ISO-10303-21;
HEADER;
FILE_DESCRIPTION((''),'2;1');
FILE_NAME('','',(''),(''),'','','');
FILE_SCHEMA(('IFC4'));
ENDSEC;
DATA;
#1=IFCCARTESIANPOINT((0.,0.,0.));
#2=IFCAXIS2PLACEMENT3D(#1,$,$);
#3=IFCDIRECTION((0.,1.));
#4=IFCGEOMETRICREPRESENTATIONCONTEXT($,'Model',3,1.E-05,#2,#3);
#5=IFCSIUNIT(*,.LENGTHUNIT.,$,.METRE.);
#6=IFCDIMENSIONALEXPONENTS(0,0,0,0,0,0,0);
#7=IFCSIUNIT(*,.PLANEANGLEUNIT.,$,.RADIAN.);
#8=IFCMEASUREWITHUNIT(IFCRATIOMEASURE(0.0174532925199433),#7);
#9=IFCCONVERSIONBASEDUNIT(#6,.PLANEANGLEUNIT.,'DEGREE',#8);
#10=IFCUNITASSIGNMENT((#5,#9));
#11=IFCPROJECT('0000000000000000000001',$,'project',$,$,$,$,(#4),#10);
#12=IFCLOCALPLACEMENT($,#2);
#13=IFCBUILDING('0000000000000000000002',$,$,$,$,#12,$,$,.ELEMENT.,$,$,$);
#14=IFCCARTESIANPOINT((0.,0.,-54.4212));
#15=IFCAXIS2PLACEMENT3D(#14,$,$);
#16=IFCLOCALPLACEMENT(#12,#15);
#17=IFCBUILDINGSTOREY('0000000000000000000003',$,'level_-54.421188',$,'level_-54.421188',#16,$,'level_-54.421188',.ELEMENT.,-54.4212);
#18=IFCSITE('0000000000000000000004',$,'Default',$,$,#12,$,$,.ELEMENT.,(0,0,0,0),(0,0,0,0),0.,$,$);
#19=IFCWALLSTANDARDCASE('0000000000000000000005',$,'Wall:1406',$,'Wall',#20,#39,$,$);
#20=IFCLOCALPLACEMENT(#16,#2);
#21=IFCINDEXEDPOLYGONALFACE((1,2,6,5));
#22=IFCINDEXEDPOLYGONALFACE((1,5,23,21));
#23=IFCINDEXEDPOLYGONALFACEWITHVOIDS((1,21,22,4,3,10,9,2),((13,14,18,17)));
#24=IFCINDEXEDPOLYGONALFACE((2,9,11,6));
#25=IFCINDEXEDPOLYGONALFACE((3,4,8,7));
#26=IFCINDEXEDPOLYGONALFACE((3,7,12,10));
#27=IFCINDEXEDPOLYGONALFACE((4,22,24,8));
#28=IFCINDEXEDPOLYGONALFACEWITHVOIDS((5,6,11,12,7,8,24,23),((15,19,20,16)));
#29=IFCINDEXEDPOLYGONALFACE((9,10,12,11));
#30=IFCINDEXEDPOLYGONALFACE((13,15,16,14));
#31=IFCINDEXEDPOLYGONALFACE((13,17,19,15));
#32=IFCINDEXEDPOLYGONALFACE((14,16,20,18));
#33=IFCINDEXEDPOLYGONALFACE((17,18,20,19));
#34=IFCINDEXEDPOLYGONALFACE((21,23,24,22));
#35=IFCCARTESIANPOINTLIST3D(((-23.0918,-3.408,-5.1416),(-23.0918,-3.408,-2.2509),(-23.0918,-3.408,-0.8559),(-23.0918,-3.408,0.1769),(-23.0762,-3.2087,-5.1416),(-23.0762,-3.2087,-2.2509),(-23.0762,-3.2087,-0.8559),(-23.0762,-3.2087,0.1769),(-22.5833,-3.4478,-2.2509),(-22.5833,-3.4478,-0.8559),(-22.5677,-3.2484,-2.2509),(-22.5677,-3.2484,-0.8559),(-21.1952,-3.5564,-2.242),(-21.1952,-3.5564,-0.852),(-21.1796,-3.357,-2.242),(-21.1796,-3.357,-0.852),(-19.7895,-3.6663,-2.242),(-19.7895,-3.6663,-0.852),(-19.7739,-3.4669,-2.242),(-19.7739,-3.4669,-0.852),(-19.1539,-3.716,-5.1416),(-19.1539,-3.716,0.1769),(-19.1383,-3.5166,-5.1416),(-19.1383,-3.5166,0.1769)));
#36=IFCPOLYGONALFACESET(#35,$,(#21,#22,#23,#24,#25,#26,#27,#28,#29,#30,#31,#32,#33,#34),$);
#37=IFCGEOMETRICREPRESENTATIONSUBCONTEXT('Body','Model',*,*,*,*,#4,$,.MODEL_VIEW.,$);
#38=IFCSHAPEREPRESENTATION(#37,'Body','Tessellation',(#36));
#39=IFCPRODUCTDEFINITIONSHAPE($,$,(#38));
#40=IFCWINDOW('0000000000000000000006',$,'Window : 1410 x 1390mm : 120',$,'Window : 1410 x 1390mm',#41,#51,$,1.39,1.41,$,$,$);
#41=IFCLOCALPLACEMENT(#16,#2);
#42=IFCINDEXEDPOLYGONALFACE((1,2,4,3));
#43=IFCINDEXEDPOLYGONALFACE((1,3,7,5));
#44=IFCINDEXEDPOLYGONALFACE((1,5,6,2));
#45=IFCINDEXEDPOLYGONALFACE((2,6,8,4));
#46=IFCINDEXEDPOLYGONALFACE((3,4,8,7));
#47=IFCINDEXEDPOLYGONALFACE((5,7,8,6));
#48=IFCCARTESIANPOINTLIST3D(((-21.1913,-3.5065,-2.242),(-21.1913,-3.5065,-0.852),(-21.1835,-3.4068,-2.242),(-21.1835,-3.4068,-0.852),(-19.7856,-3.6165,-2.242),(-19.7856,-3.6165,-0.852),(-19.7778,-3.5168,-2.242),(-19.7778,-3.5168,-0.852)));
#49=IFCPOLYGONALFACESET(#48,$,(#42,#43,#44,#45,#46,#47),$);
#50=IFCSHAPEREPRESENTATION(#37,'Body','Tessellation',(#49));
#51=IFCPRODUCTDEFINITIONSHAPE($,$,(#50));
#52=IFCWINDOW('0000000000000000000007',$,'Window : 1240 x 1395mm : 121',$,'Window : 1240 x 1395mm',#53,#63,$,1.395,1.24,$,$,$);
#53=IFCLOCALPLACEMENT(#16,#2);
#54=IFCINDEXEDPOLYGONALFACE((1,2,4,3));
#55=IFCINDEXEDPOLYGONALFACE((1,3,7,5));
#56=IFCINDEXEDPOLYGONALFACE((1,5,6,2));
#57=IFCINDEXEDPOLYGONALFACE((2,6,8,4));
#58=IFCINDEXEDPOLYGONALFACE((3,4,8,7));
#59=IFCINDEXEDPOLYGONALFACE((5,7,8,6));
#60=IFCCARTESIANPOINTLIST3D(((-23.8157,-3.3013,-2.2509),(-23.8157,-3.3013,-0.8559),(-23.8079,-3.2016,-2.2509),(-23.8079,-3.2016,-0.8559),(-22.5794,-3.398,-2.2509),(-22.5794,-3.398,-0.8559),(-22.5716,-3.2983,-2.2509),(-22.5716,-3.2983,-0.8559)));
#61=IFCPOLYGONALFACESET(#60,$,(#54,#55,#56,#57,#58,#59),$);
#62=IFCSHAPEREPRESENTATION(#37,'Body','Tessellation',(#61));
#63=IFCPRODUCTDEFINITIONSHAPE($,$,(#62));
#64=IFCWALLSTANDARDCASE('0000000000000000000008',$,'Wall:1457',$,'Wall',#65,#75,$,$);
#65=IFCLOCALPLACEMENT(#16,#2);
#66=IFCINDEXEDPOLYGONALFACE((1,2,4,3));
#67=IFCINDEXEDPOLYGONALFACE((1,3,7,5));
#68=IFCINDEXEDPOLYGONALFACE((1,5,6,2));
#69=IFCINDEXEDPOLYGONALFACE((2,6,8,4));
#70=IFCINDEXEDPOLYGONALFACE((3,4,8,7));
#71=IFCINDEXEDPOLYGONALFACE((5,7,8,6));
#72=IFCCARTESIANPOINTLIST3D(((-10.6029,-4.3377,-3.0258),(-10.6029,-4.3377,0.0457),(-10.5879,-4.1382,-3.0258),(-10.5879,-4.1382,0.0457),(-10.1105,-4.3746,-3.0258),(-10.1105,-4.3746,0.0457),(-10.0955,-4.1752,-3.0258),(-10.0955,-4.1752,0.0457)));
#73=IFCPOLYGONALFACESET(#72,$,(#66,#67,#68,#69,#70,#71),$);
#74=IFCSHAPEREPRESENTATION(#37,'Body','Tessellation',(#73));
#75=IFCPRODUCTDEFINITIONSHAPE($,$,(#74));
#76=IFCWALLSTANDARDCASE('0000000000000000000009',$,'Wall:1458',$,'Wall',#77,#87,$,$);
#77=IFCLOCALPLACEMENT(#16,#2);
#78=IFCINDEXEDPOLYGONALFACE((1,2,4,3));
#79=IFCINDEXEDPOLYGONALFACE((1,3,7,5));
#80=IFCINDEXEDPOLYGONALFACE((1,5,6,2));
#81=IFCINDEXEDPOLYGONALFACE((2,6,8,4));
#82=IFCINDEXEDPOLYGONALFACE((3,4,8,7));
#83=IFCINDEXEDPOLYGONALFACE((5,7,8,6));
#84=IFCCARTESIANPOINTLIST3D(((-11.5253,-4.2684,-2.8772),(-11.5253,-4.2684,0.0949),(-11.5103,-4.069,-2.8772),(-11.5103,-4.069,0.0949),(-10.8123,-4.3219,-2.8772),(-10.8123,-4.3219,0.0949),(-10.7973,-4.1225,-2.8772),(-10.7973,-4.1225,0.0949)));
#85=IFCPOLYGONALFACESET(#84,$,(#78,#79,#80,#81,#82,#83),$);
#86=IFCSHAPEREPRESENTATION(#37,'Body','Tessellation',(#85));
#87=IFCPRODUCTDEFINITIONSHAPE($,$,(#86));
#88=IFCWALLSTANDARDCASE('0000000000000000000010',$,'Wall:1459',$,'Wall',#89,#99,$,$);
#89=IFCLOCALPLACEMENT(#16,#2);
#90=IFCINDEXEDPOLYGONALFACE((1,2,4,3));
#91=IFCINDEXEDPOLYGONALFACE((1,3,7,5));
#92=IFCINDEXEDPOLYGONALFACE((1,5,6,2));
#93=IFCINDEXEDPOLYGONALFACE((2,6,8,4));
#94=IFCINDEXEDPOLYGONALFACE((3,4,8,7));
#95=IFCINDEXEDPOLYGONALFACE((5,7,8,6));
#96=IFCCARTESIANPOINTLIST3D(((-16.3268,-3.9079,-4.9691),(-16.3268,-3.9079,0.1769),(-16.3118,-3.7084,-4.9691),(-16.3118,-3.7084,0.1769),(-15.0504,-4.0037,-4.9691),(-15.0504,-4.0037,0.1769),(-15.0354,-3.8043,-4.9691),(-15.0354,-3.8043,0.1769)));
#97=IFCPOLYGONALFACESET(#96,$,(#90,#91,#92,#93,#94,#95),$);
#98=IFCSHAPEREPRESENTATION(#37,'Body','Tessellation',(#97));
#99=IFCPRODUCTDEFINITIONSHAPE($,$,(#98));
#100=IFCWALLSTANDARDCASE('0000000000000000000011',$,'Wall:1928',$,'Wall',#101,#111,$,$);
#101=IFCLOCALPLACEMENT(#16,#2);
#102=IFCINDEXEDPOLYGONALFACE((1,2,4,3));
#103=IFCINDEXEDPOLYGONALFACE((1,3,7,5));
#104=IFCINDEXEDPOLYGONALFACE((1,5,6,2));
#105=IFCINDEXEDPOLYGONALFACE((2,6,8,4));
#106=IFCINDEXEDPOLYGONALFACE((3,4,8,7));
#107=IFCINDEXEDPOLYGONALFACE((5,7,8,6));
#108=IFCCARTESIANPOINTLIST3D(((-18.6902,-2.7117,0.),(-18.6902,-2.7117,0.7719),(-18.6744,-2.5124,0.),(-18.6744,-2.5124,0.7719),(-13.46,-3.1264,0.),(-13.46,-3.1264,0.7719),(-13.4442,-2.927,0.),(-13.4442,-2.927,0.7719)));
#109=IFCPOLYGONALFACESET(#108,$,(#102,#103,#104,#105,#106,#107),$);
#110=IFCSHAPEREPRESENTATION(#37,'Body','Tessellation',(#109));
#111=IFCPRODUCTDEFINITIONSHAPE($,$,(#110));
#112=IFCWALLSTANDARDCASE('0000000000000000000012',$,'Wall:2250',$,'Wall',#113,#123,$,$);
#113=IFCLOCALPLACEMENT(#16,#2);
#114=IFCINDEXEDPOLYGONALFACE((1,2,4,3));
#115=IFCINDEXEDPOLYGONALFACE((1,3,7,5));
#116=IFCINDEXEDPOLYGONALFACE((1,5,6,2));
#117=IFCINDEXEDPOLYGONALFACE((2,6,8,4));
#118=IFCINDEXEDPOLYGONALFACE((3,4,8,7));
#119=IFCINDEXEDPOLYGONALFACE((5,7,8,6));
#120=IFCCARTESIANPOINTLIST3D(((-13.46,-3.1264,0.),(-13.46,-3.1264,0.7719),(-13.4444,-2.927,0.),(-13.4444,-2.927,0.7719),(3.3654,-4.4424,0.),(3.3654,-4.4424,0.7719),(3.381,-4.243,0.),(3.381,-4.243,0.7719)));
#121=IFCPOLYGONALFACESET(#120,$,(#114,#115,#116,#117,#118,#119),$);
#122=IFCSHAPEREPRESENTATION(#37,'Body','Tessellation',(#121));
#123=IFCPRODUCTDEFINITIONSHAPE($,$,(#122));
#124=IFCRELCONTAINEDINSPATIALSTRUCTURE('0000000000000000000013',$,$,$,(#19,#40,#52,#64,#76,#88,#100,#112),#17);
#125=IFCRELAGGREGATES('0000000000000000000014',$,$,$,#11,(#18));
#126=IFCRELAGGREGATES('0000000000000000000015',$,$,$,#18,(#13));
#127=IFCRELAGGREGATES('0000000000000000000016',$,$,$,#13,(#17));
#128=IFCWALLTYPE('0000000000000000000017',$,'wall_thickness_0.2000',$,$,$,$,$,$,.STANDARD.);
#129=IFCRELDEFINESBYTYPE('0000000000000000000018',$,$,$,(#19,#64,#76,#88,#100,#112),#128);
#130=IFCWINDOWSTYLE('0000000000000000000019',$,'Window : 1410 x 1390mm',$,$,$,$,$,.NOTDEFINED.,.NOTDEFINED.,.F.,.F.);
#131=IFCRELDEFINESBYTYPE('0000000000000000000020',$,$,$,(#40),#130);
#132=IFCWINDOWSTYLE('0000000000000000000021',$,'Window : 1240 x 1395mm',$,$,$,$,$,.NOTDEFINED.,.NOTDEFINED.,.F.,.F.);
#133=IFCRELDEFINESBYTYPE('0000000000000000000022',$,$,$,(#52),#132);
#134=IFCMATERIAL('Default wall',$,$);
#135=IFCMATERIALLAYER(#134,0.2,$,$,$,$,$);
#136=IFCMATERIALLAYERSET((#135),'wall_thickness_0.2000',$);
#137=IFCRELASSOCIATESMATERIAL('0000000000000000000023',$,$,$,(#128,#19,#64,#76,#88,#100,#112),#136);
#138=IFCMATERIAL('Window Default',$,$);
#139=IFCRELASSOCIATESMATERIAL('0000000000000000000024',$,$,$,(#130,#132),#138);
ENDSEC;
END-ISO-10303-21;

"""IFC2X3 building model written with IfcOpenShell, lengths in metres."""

from ifc_helpers import new_model, entity, si_unit, converted_unit, direction, frame, frame_2d, origin, origin_2d_with_axis, place, context, subcontext, project, spatial, polyline, rectangle, outline, extrude, source, transform, mapped, material, layer, layer_set, layer_usage, type_object, type_shapes, element, fill, save


model = new_model("IFC2X3")

# Units and contexts
model_context = context("Model", 3, precision=1e-05, world=origin(), true_north=direction((0.0, 1.0)))
body_context = subcontext(model_context, "Body", "Model", "MODEL_VIEW")
ifc_project = project(units=[si_unit("LENGTHUNIT", "METRE"), converted_unit("PLANEANGLEUNIT", "DEGREE", entity("IfcRatioMeasure", 0.0174532925199433), si_unit("PLANEANGLEUNIT", "RADIAN"), dimensions=[0, 0, 0, 0, 0, 0, 0])], contexts=[model_context])

# Site, building, storey
placement_1 = place(None, origin())
site = spatial("IfcSite", under=ifc_project, at=placement_1, Name="Default", CompositionType="ELEMENT", RefLatitude=(0, 0, 0, 0), RefLongitude=(0, 0, 0, 0), RefElevation=0.0)
building = spatial("IfcBuilding", under=site, at=placement_1, CompositionType="ELEMENT")
storey_placement = place(placement_1, frame((0.0, 0.0, -54.4212)))
storey = spatial("IfcBuildingStorey", under=building, at=storey_placement, Name="level_-54.421188", ObjectType="level_-54.421188", LongName="level_-54.421188", CompositionType="ELEMENT", Elevation=-54.4212)

# Shared definitions
ifc_material_1 = material(Name="Default wall")
ifc_layer = layer(ifc_material_1, 0.2)
ifc_layer_set = layer_set([ifc_layer], Name="wall_thickness_0.2000")
ifc_layer_usage = layer_usage(ifc_layer_set, "AXIS2", "POSITIVE", -0.1)
wall_type = type_object("IfcWallType", Name="wall_thickness_0.2000", PredefinedType="STANDARD", material=ifc_layer_set)
ifc_material_2 = material(Name="Window Default")

# Shared definitions
window_style_1 = type_object("IfcWindowStyle", Name="Window : 1410 x 1390mm", ConstructionType="NOTDEFINED", OperationType="NOTDEFINED", ParameterTakesPrecedence=False, Sizeable=False, material=ifc_material_2)
shared_shape_1 = source(origin(), body_context, "Body", "SweptSolid", [
    extrude(rectangle(XDim=0.1, YDim=1.41, at=origin_2d_with_axis()), frame((0.705, 0.1, 0.0), z_axis=(0.0, 0.0, 1.0), x_axis=(0.0, 1.0, 0.0)), (0.0, 0.0, 1.0), 1.39),
])
type_shapes(window_style_1, [shared_shape_1])

# Wall, openings, windows
placement_2 = place(placement_1, frame((0.0, 0.0, -59.5628)))
wall_1_placement = place(placement_2, frame((-19.1461, -3.6163, 0.0), z_axis=(0.0, 0.0, 1.0), x_axis=(-0.996956, 0.077972, 0.0)))
wall_1 = element("IfcWallStandardCase", 1, at=wall_1_placement, inside=storey, type_object=wall_type, material=ifc_layer_usage, Name="Wall:1406", ObjectType="Wall", context=body_context, shape_type="SweptSolid", body=[
    extrude(outline(polyline([(3.9499, -0.1), (3.9499, 0.1), (0.0, 0.1), (0.0, -0.1), (3.9499, -0.1)])), origin(), (0.0, 0.0, 1.0), 5.3185),
])
opening_1_placement = place(wall_1_placement, frame((0.6376, -0.1, 2.8996)))
opening_1 = element("IfcOpeningElement", 2, at=opening_1_placement, cuts=wall_1, ObjectType="Opening", context=body_context, shape_type="SweptSolid", body=[
    extrude(rectangle(XDim=1.41, YDim=1.39, at=frame_2d((0.695, 0.705), x_axis=(0.0, 1.0))), frame((0.0, 0.0, 0.0), z_axis=(0.0, 1.0, 0.0), x_axis=(0.0, 0.0, 1.0)), (0.0, 0.0, 1.0), 0.2),
])
opening_2_placement = place(wall_1_placement, frame((3.4399, -0.1, 2.8907)))
opening_2 = element("IfcOpeningElement", 3, at=opening_2_placement, cuts=wall_1, ObjectType="Opening", context=body_context, shape_type="SweptSolid", body=[
    extrude(rectangle(XDim=1.24, YDim=1.395, at=frame_2d((0.6975, 0.62), x_axis=(0.0, 1.0))), frame((0.0, 0.0, 0.0), z_axis=(0.0, 1.0, 0.0), x_axis=(0.0, 0.0, 1.0)), (0.0, 0.0, 1.0), 0.2),
])
window_1_placement = place(opening_1_placement, origin())
window_1 = element("IfcWindow", 4, at=window_1_placement, inside=storey, type_object=window_style_1, Name="Window : 1410 x 1390mm : 120", ObjectType="Window : 1410 x 1390mm", OverallHeight=1.39, OverallWidth=1.41, context=body_context, shape_type="MappedRepresentation", body=[
    mapped(shared_shape_1, transform((0.0, 0.0, 0.0), scale=1.0)),
])
fill(opening_1, window_1)
window_style_2 = type_object("IfcWindowStyle", Name="Window : 1240 x 1395mm", ConstructionType="NOTDEFINED", OperationType="NOTDEFINED", ParameterTakesPrecedence=False, Sizeable=False, material=ifc_material_2)
shared_shape_2 = source(origin(), body_context, "Body", "SweptSolid", [
    extrude(rectangle(XDim=0.1, YDim=1.24, at=origin_2d_with_axis()), frame((0.62, 0.1, 0.0), z_axis=(0.0, 0.0, 1.0), x_axis=(0.0, 1.0, 0.0)), (0.0, 0.0, 1.0), 1.395),
])
type_shapes(window_style_2, [shared_shape_2])
window_2_placement = place(opening_2_placement, origin())
window_2 = element("IfcWindow", 5, at=window_2_placement, inside=storey, type_object=window_style_2, Name="Window : 1240 x 1395mm : 121", ObjectType="Window : 1240 x 1395mm", OverallHeight=1.395, OverallWidth=1.24, context=body_context, shape_type="MappedRepresentation", body=[
    mapped(shared_shape_2, transform((0.0, 0.0, 0.0), scale=1.0)),
])
fill(opening_2, window_2)

# Walls
placement_3 = place(placement_1, frame((0.0, 0.0, -57.447)))
wall_2_placement = place(placement_3, frame((-10.5954, -4.2379, 0.0), z_axis=(0.0, 0.0, 1.0), x_axis=(0.997193, -0.074878, 0.0)))
element("IfcWallStandardCase", 6, at=wall_2_placement, inside=storey, type_object=wall_type, material=ifc_layer_usage, Name="Wall:1457", ObjectType="Wall", context=body_context, shape_type="SweptSolid", body=[
    extrude(outline(polyline([(0.4938, -0.1), (0.4938, 0.1), (0.0, 0.1), (0.0, -0.1), (0.4938, -0.1)])), origin(), (0.0, 0.0, 1.0), 3.0716),
])
placement_4 = place(placement_1, frame((0.0, 0.0, -57.2984)))
wall_3_placement = place(placement_4, frame((-11.5178, -4.1687, 0.0), z_axis=(0.0, 0.0, 1.0), x_axis=(0.997193, -0.074878, 0.0)))
element("IfcWallStandardCase", 7, at=wall_3_placement, inside=storey, type_object=wall_type, material=ifc_layer_usage, Name="Wall:1458", ObjectType="Wall", context=body_context, shape_type="SweptSolid", body=[
    extrude(outline(polyline([(0.715, -0.1), (0.715, 0.1), (0.0, 0.1), (0.0, -0.1), (0.715, -0.1)])), origin(), (0.0, 0.0, 1.0), 2.9721),
])
placement_5 = place(placement_1, frame((0.0, 0.0, -59.3903)))
wall_4_placement = place(placement_5, frame((-16.3193, -3.8081, 0.0), z_axis=(0.0, 0.0, 1.0), x_axis=(0.997193, -0.074878, 0.0)))
element("IfcWallStandardCase", 8, at=wall_4_placement, inside=storey, type_object=wall_type, material=ifc_layer_usage, Name="Wall:1459", ObjectType="Wall", context=body_context, shape_type="SweptSolid", body=[
    extrude(outline(polyline([(1.28, -0.1), (1.28, 0.1), (0.0, 0.1), (0.0, -0.1), (1.28, -0.1)])), origin(), (0.0, 0.0, 1.0), 5.146),
])
wall_5_placement = place(storey_placement, frame((-18.6823, -2.6121, 0.0), z_axis=(0.0, 0.0, 1.0), x_axis=(0.996872, -0.079031, 0.0)))
element("IfcWallStandardCase", 9, at=wall_5_placement, inside=storey, type_object=wall_type, material=ifc_layer_usage, Name="Wall:1928", ObjectType="Wall", context=body_context, shape_type="SweptSolid", body=[
    extrude(outline(polyline([(5.2466, -0.1), (5.2466, 0.1), (0.0, 0.1), (0.0, -0.1), (5.2466, -0.1)])), origin(), (0.0, 0.0, 1.0), 0.7719),
])
wall_6_placement = place(storey_placement, frame((-13.4522, -3.0267, 0.0), z_axis=(0.0, 0.0, 1.0), x_axis=(0.996955, -0.077977, 0.0)))
element("IfcWallStandardCase", 10, at=wall_6_placement, inside=storey, type_object=wall_type, material=ifc_layer_usage, Name="Wall:2250", ObjectType="Wall", context=body_context, shape_type="SweptSolid", body=[
    extrude(outline(polyline([(16.8768, -0.1), (16.8768, 0.1), (0.0, 0.1), (0.0, -0.1), (16.8768, -0.1)])), origin(), (0.0, 0.0, 1.0), 0.7719),
])

save(model, "model.ifc")
